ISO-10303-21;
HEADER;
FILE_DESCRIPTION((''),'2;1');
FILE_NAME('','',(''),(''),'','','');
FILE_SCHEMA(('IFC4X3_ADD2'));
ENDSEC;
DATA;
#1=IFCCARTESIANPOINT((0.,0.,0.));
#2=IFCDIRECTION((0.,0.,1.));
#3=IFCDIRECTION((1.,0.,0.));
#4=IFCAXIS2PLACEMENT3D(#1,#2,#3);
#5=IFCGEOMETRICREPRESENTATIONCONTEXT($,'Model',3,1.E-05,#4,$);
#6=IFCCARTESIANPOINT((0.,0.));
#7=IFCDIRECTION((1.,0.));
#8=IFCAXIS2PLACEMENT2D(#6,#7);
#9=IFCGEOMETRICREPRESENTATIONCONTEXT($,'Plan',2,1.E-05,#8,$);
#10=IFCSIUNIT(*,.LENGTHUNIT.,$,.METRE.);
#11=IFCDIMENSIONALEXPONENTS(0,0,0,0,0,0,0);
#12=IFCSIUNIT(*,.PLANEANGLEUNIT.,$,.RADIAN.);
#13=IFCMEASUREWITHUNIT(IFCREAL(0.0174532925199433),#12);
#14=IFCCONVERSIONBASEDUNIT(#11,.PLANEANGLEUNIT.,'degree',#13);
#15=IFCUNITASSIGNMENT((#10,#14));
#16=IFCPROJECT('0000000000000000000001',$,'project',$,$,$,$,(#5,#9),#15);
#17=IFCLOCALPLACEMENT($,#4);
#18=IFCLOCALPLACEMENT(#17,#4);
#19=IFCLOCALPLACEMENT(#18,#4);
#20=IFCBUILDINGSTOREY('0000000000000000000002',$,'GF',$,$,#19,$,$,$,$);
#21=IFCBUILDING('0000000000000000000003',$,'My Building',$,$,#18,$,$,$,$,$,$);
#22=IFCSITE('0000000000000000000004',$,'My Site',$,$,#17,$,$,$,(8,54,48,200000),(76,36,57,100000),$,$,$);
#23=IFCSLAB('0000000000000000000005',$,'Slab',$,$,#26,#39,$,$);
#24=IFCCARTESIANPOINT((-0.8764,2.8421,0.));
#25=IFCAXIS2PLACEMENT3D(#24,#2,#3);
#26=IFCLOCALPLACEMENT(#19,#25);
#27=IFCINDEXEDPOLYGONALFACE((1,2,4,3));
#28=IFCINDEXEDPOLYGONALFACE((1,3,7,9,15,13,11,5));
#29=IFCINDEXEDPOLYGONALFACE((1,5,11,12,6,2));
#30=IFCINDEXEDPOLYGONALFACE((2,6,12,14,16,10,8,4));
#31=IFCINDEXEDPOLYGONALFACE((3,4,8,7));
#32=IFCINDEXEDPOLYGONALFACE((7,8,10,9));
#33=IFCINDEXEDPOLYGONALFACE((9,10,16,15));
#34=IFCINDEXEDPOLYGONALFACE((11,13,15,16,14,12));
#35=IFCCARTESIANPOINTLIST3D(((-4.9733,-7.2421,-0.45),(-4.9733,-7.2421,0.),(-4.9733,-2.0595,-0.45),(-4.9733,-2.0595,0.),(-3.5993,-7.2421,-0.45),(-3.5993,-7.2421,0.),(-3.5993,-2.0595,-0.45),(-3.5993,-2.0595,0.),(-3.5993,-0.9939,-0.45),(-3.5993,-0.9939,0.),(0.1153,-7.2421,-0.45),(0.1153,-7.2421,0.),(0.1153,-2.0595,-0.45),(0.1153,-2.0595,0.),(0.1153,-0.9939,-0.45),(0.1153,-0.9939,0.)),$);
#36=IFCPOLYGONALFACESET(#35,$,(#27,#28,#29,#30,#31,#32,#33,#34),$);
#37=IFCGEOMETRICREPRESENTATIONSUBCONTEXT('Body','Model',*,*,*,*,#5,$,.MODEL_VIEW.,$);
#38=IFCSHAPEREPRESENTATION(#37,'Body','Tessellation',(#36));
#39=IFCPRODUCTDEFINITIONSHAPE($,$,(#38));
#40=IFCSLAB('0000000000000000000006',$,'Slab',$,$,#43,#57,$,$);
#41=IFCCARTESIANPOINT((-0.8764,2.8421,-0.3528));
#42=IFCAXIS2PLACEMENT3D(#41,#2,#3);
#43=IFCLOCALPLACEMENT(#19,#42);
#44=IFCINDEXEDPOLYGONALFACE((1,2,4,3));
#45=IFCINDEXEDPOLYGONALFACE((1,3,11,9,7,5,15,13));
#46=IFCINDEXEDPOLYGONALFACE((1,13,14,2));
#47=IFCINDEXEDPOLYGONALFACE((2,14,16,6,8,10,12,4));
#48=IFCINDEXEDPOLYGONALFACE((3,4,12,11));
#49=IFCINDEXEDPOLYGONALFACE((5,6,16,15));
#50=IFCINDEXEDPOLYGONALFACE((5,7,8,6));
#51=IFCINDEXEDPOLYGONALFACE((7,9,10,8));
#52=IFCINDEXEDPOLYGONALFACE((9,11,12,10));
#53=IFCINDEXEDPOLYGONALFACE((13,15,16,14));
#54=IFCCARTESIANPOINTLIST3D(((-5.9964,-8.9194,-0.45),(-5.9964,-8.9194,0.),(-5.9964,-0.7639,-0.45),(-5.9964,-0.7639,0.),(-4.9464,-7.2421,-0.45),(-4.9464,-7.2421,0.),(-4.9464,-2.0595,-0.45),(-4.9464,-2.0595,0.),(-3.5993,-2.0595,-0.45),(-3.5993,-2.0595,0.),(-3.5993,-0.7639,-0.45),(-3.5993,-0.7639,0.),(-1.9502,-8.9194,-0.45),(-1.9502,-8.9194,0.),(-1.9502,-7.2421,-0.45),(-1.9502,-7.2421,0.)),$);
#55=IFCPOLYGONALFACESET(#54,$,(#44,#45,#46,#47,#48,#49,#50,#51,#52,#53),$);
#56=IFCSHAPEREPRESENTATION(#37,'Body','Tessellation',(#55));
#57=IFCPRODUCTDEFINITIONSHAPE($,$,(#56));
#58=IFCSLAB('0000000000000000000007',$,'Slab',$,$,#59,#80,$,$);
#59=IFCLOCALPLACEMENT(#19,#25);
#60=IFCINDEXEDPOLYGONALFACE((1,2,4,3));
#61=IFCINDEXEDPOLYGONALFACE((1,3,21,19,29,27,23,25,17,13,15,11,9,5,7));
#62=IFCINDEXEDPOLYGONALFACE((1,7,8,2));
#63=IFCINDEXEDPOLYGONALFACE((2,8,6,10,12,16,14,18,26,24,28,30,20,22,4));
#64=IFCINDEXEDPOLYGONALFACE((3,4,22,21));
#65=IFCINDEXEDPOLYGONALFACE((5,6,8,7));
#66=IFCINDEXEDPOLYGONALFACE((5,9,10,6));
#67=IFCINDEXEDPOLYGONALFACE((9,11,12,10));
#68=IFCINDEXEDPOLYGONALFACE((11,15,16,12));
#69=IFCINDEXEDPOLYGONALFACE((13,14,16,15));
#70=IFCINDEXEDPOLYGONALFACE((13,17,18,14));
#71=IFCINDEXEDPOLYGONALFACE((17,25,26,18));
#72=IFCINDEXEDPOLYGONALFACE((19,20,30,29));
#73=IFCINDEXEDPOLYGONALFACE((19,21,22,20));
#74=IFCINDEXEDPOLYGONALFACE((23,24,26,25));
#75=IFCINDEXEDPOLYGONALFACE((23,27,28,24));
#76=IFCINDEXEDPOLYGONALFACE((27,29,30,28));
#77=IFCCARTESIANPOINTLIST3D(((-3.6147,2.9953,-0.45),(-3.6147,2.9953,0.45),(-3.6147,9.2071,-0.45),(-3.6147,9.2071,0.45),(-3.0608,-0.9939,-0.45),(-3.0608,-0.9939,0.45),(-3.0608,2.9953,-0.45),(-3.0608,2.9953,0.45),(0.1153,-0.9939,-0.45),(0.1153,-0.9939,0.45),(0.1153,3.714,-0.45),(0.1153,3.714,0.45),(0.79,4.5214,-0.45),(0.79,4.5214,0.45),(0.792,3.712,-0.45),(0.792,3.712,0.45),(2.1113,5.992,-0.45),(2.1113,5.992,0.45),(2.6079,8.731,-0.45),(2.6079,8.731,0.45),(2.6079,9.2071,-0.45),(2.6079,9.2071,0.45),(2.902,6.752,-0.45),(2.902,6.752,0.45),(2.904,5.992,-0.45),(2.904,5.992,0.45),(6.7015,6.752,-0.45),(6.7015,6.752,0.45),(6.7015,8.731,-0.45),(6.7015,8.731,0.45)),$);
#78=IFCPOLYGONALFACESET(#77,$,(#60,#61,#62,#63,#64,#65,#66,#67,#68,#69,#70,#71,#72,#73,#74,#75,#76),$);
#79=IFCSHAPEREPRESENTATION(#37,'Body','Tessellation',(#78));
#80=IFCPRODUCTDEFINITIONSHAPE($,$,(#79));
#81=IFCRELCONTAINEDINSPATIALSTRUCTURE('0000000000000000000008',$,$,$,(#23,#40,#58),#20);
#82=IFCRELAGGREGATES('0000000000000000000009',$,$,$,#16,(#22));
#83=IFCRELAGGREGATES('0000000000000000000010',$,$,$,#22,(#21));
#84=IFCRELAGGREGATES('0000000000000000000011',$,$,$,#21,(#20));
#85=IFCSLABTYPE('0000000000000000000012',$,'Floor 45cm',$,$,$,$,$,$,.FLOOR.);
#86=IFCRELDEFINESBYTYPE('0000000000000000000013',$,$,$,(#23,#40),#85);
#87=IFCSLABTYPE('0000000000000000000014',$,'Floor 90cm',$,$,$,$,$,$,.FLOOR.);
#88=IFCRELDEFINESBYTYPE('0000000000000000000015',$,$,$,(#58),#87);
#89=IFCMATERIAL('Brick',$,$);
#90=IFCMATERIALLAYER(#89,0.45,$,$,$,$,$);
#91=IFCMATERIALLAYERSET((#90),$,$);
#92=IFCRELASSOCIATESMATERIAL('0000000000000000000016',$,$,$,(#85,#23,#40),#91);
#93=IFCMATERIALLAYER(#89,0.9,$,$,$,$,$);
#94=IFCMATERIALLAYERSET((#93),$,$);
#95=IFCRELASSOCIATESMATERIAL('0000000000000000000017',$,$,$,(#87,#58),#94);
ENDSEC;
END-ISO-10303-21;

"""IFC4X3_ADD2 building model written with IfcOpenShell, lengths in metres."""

from ifc_helpers import new_model, entity, si_unit, converted_unit, frame, origin_with_axes, origin_2d_with_axis, place, context, subcontext, project, spatial, indexed_curve, outline, extrude, material, layer, layer_set, layer_usage, type_object, element, save


model = new_model("IFC4X3_ADD2")

# Units and contexts
model_context = context("Model", 3, precision=1e-05, world=origin_with_axes())
plan_context = context("Plan", 2, precision=1e-05, world=origin_2d_with_axis())
body_context = subcontext(model_context, "Body", "Model", "MODEL_VIEW")
ifc_project = project(units=[si_unit("LENGTHUNIT", "METRE"), converted_unit("PLANEANGLEUNIT", "degree", entity("IfcReal", 0.0174532925199433), si_unit("PLANEANGLEUNIT", "RADIAN"), dimensions=[0, 0, 0, 0, 0, 0, 0])], contexts=[model_context, plan_context])

# Site, building, storey
site_placement = place(None, origin_with_axes())
site = spatial("IfcSite", under=ifc_project, at=site_placement, Name="My Site", RefLatitude=(8, 54, 48, 200000), RefLongitude=(76, 36, 57, 100000))
building_placement = place(site_placement, origin_with_axes())
building = spatial("IfcBuilding", under=site, at=building_placement, Name="My Building")
storey_placement = place(building_placement, origin_with_axes())
storey = spatial("IfcBuildingStorey", under=building, at=storey_placement, Name="GF")

# Slabs
ifc_material_1 = material(Name="Brick")
ifc_layer_1 = layer(ifc_material_1, 0.45)
ifc_layer_set_1 = layer_set([ifc_layer_1])
ifc_layer_usage_1 = layer_usage(ifc_layer_set_1, "AXIS3", "POSITIVE", -0.45)
slab_type_1 = type_object("IfcSlabType", Name="Floor 45cm", PredefinedType="FLOOR", material=ifc_layer_set_1)
slab_1_placement = place(storey_placement, frame((-0.8764, 2.8421, 0.0), z_axis=(0.0, 0.0, 1.0), x_axis=(1.0, 0.0, 0.0)))
element("IfcSlab", 1, at=slab_1_placement, inside=storey, type_object=slab_type_1, material=ifc_layer_usage_1, Name="Slab", context=body_context, shape_type="SweptSolid", body=[
    extrude(outline(indexed_curve([(0.1153, -0.9939), (0.1153, -2.0595), (0.1153, -7.2421), (-3.5993, -7.2421), (-4.9733, -7.2421), (-4.9733, -2.0595), (-3.5993, -2.0595), (-3.5993, -0.9939), (0.1153, -0.9939)])), frame((0.0, 0.0, -0.45), z_axis=(0.0, 0.0, 1.0), x_axis=(1.0, 0.0, 0.0)), (0.0, 0.0, 1.0), 0.45),
])
ifc_layer_usage_2 = layer_usage(ifc_layer_set_1, "AXIS3", "POSITIVE", -0.45)
slab_2_placement = place(storey_placement, frame((-0.8764, 2.8421, -0.3528), z_axis=(0.0, 0.0, 1.0), x_axis=(1.0, 0.0, 0.0)))
element("IfcSlab", 2, at=slab_2_placement, inside=storey, type_object=slab_type_1, material=ifc_layer_usage_2, Name="Slab", context=body_context, shape_type="SweptSolid", body=[
    extrude(outline(indexed_curve([(-3.5993, -0.7639), (-3.5993, -2.0595), (-4.9464, -2.0595), (-4.9464, -7.2421), (-1.9502, -7.2421), (-1.9502, -8.9194), (-5.9964, -8.9194), (-5.9964, -0.7639), (-3.5993, -0.7639)])), frame((0.0, 0.0, -0.45), z_axis=(0.0, 0.0, 1.0), x_axis=(1.0, 0.0, 0.0)), (0.0, 0.0, 1.0), 0.45),
])
ifc_layer_2 = layer(ifc_material_1, 0.9)
ifc_layer_set_2 = layer_set([ifc_layer_2])
slab_type_2 = type_object("IfcSlabType", Name="Floor 90cm", PredefinedType="FLOOR", material=ifc_layer_set_2)
ifc_layer_usage_3 = layer_usage(ifc_layer_set_2, "AXIS3", "POSITIVE", -0.45)
slab_3_placement = place(storey_placement, frame((-0.8764, 2.8421, 0.0), z_axis=(0.0, 0.0, 1.0), x_axis=(1.0, 0.0, 0.0)))
element("IfcSlab", 3, at=slab_3_placement, inside=storey, type_object=slab_type_2, material=ifc_layer_usage_3, Name="Slab", context=body_context, shape_type="SweptSolid", body=[
    extrude(outline(indexed_curve([(6.7015, 6.752), (2.902, 6.752), (2.904, 5.992), (2.1113, 5.992), (0.79, 4.5214), (0.792, 3.712), (0.1153, 3.714), (0.1153, -0.9939), (-3.0608, -0.9939), (-3.0608, 2.9953), (-3.6147, 2.9953), (-3.6147, 9.2071), (2.6079, 9.2071), (2.6079, 8.731), (6.7015, 8.731), (6.7015, 6.752)])), frame((0.0, 0.0, -0.45), z_axis=(0.0, 0.0, 1.0), x_axis=(1.0, 0.0, 0.0)), (0.0, 0.0, 1.0), 0.9),
])

save(model, "model.ifc")
